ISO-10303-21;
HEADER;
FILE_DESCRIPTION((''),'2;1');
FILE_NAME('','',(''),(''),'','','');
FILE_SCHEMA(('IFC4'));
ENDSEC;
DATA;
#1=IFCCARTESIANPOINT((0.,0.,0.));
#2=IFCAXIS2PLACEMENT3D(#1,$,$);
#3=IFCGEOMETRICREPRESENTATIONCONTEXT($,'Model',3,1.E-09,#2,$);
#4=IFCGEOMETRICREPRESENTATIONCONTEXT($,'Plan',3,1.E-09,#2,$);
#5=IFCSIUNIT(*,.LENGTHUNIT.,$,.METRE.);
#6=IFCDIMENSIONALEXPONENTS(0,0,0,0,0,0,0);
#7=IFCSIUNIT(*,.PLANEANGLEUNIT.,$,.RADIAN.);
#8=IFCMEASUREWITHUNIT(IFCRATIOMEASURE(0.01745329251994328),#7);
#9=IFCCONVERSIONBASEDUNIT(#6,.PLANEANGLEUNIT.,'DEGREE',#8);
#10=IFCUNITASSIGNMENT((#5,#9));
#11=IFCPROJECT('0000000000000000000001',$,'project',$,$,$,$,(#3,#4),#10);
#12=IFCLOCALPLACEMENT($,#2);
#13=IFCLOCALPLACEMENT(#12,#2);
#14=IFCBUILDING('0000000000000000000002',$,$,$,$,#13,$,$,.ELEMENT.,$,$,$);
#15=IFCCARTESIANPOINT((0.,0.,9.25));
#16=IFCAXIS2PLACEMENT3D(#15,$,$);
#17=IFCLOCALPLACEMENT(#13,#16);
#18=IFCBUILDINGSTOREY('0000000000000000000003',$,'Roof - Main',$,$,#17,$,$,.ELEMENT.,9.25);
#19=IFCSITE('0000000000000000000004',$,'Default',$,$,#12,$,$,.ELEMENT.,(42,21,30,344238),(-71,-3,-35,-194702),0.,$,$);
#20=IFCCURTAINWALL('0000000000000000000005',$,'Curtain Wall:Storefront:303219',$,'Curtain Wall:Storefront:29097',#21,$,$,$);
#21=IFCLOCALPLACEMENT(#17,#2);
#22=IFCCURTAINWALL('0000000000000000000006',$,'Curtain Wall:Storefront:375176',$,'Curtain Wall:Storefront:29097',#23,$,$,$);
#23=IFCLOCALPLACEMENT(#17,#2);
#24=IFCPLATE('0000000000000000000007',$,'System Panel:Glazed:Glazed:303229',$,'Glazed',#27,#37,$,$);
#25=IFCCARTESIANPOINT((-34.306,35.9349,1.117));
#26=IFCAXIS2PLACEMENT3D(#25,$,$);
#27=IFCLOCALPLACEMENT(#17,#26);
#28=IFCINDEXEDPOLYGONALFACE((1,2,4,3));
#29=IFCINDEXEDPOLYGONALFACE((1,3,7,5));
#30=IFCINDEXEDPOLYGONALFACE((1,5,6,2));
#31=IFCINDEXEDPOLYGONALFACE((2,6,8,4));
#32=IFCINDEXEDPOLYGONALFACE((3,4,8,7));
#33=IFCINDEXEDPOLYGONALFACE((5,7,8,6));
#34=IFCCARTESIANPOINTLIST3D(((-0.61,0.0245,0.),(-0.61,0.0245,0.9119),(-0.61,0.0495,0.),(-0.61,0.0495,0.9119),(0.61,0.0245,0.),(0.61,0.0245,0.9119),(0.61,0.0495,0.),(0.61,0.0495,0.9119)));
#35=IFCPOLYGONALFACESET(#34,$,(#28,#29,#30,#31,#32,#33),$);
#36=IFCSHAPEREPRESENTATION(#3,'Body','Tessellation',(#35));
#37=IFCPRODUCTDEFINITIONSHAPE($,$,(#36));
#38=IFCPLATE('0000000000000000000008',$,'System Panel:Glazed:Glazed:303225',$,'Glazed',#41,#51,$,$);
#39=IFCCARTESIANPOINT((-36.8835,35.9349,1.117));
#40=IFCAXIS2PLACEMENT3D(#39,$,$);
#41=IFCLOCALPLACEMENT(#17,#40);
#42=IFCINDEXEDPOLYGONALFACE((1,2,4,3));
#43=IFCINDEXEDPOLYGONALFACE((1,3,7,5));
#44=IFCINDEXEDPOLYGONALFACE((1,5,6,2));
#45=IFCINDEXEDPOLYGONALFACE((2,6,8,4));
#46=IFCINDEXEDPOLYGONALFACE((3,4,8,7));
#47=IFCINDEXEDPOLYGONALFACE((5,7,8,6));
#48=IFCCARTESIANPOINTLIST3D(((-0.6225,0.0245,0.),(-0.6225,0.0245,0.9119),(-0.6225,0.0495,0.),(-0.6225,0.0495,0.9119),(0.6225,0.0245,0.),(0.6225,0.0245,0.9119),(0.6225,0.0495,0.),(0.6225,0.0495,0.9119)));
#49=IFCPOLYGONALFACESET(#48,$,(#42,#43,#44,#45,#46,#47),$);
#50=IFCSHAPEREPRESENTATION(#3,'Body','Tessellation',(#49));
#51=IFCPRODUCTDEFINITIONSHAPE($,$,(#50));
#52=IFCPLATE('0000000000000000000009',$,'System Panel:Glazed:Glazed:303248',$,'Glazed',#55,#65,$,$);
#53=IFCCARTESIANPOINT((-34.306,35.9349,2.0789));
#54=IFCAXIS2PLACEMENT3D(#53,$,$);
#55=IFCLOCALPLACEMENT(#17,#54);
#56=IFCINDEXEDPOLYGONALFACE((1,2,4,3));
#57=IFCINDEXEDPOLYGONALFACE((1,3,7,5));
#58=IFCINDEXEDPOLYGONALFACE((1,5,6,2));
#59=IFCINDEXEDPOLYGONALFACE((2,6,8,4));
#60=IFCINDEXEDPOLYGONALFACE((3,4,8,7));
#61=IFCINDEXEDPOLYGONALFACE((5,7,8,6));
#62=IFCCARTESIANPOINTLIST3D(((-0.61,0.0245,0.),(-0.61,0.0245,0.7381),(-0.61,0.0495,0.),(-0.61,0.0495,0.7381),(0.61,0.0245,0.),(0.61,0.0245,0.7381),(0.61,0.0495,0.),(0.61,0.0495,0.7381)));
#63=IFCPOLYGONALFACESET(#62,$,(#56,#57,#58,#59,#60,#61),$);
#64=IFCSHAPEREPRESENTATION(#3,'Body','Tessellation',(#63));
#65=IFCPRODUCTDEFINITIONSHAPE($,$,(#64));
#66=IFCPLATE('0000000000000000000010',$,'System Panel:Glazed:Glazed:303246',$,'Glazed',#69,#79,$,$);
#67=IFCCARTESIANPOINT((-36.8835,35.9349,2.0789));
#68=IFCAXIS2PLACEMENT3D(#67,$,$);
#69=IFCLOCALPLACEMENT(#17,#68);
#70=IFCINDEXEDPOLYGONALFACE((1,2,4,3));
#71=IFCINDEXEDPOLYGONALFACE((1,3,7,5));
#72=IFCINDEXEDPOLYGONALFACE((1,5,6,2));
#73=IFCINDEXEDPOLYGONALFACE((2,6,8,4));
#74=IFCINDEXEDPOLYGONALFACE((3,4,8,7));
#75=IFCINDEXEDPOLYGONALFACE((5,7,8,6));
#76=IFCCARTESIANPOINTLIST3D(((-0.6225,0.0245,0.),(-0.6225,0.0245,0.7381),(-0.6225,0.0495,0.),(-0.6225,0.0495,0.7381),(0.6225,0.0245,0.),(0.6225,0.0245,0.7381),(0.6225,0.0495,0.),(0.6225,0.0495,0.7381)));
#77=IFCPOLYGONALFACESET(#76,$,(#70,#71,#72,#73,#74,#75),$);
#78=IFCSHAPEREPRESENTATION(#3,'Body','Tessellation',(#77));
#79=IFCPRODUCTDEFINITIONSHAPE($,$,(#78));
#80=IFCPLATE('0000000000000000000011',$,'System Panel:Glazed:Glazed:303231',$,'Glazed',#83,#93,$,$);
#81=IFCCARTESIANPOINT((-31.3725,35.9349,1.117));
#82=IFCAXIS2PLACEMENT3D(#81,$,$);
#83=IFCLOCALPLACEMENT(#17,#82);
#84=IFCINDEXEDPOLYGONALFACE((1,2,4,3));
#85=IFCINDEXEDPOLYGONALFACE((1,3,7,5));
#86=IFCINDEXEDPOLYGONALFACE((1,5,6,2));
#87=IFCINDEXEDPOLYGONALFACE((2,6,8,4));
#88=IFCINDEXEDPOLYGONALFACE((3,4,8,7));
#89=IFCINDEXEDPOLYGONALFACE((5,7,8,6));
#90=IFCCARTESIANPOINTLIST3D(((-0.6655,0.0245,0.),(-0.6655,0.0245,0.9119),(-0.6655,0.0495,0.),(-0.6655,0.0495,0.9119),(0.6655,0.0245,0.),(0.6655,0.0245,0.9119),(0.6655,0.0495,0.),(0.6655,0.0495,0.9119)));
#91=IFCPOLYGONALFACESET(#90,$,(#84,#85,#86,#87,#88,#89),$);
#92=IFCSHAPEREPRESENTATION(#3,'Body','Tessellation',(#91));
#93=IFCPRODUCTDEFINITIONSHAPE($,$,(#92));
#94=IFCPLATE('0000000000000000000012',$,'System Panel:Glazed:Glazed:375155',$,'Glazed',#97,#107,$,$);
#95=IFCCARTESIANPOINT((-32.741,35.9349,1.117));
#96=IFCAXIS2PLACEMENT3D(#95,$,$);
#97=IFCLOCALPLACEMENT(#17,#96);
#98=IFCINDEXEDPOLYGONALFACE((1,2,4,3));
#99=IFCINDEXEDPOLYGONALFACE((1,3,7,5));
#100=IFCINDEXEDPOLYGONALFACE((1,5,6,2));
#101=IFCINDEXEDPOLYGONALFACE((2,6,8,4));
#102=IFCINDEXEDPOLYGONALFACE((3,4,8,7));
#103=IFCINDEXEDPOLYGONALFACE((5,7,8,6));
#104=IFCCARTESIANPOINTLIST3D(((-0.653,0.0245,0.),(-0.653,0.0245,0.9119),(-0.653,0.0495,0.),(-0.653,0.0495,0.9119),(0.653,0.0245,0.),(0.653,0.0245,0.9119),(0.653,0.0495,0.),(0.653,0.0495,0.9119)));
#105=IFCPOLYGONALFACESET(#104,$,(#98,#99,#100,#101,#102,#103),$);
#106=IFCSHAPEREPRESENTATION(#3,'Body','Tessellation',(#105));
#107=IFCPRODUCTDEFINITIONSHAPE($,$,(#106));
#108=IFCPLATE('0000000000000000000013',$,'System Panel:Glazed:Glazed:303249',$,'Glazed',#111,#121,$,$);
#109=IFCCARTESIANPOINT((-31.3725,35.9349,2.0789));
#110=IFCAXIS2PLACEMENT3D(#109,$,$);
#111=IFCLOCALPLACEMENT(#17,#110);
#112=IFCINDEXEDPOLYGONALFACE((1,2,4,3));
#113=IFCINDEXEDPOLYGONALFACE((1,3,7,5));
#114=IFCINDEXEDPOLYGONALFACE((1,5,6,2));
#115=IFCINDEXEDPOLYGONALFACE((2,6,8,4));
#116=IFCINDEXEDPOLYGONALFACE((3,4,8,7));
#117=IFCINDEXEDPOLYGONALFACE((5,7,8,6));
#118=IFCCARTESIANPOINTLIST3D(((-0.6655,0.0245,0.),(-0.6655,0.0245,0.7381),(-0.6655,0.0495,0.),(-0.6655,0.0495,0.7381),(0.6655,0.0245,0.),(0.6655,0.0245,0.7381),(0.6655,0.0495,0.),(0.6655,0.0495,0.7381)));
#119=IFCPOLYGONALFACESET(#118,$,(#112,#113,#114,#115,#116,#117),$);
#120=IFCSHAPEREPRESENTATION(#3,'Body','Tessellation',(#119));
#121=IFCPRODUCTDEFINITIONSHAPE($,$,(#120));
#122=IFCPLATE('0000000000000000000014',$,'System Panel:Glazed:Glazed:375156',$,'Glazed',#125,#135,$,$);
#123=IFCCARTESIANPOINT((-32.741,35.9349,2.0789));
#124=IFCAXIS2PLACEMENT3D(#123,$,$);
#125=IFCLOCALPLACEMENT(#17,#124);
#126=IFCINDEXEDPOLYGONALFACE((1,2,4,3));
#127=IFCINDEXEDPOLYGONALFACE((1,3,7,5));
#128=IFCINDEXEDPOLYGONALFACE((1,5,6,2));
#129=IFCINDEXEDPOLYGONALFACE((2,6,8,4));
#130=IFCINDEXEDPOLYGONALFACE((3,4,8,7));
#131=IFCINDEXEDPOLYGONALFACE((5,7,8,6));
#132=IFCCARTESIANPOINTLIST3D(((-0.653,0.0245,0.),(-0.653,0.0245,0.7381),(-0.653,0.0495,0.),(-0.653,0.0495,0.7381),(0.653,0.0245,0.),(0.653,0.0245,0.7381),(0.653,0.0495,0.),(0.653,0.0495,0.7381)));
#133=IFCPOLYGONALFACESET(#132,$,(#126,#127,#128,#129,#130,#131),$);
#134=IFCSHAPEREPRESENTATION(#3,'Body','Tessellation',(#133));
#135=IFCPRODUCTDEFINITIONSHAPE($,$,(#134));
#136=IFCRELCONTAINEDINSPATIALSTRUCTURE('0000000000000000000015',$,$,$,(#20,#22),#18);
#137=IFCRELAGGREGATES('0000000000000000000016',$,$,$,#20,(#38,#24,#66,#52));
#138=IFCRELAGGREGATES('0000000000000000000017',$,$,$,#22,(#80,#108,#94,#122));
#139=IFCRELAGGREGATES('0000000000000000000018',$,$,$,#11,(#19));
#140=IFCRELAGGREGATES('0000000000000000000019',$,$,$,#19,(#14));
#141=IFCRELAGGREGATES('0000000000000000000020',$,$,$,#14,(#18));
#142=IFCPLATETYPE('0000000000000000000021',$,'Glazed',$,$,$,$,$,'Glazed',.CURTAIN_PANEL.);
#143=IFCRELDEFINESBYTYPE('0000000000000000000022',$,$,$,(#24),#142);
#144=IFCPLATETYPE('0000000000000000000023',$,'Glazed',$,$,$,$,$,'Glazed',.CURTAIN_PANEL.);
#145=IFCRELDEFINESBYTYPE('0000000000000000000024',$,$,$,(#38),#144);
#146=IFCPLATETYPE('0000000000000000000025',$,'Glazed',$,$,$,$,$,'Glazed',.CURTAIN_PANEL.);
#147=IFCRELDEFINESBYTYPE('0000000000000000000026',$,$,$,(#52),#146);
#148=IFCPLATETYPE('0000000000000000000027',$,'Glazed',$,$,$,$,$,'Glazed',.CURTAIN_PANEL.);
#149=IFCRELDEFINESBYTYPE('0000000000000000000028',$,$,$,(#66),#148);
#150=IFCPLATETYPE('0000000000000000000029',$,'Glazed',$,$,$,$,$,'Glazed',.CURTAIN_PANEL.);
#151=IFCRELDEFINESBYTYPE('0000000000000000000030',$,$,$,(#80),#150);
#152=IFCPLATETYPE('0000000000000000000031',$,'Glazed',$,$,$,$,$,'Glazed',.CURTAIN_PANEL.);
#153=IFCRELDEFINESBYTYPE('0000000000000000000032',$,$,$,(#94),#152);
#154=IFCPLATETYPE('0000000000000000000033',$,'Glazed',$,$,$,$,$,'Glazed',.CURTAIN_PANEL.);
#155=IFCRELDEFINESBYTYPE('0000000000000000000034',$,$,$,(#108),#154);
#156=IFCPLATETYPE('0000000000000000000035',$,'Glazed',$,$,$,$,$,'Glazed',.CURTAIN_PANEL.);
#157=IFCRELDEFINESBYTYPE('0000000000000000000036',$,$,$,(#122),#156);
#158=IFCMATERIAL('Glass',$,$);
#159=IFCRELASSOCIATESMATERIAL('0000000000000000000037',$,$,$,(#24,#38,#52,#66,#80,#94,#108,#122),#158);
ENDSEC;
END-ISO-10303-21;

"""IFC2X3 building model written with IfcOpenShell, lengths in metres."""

from ifc_helpers import new_model, entity, si_unit, converted_unit, frame, origin, origin_2d_with_axis, place, context, project, spatial, rectangle, extrude, source, transform, mapped, material, type_object, type_shapes, element, aggregate, save


model = new_model("IFC2X3")

# Units and contexts
model_context = context("Model", 3, precision=1e-09, world=origin())
plan_context = context("Plan", 3, precision=1e-09, world=origin())
ifc_project = project(units=[si_unit("LENGTHUNIT", "METRE"), converted_unit("PLANEANGLEUNIT", "DEGREE", entity("IfcRatioMeasure", 0.01745329251994328), si_unit("PLANEANGLEUNIT", "RADIAN"), dimensions=[0, 0, 0, 0, 0, 0, 0])], contexts=[model_context, plan_context])

# Site, building, storey
site_placement = place(None, origin())
site = spatial("IfcSite", under=ifc_project, at=site_placement, Name="Default", CompositionType="ELEMENT", RefLatitude=(42, 21, 30, 344238), RefLongitude=(-71, -3, -35, -194702), RefElevation=0.0)
building_placement = place(site_placement, origin())
building = spatial("IfcBuilding", under=site, at=building_placement, CompositionType="ELEMENT")
storey_placement = place(building_placement, frame((0.0, 0.0, 9.25)))
storey = spatial("IfcBuildingStorey", under=building, at=storey_placement, Name="Roof - Main", CompositionType="ELEMENT", Elevation=9.25)

# Curtain wall
curtain_wall_1_placement = place(storey_placement, origin())
curtain_wall_1 = element("IfcCurtainWall", 1, at=curtain_wall_1_placement, inside=storey, Name="Curtain Wall:Storefront:303219", ObjectType="Curtain Wall:Storefront:29097")

# Curtain wall
curtain_wall_2_placement = place(storey_placement, origin())
curtain_wall_2 = element("IfcCurtainWall", 2, at=curtain_wall_2_placement, inside=storey, Name="Curtain Wall:Storefront:375176", ObjectType="Curtain Wall:Storefront:29097")

# Plates
ifc_material_1 = material(Name="Glass")
plate_type_1 = type_object("IfcPlateType", Name="Glazed", ElementType="Glazed", PredefinedType="CURTAIN_PANEL")
shared_shape_1 = source(origin(), model_context, "Body", "SweptSolid", [
    extrude(rectangle(XDim=0.025, YDim=1.22, at=origin_2d_with_axis()), frame((0.0, 0.037, 0.0), z_axis=(0.0, 0.0, 1.0), x_axis=(0.0, 1.0, 0.0)), (0.0, 0.0, 1.0), 0.9119),
])
type_shapes(plate_type_1, [shared_shape_1])
plate_1_placement = place(storey_placement, frame((-34.306, 35.9349, 1.117)))
plate_1 = element("IfcPlate", 3, at=plate_1_placement, type_object=plate_type_1, material=ifc_material_1, Name="System Panel:Glazed:Glazed:303229", ObjectType="Glazed", context=model_context, shape_type="MappedRepresentation", body=[
    mapped(shared_shape_1, transform((0.0, 0.0, 0.0), scale=1.0)),
])
plate_type_2 = type_object("IfcPlateType", Name="Glazed", ElementType="Glazed", PredefinedType="CURTAIN_PANEL")
shared_shape_2 = source(origin(), model_context, "Body", "SweptSolid", [
    extrude(rectangle(XDim=0.025, YDim=1.245, at=origin_2d_with_axis()), frame((0.0, 0.037, 0.0), z_axis=(0.0, 0.0, 1.0), x_axis=(0.0, 1.0, 0.0)), (0.0, 0.0, 1.0), 0.9119),
])
type_shapes(plate_type_2, [shared_shape_2])
plate_2_placement = place(storey_placement, frame((-36.8835, 35.9349, 1.117)))
plate_2 = element("IfcPlate", 4, at=plate_2_placement, type_object=plate_type_2, material=ifc_material_1, Name="System Panel:Glazed:Glazed:303225", ObjectType="Glazed", context=model_context, shape_type="MappedRepresentation", body=[
    mapped(shared_shape_2, transform((0.0, 0.0, 0.0), scale=1.0)),
])
plate_type_3 = type_object("IfcPlateType", Name="Glazed", ElementType="Glazed", PredefinedType="CURTAIN_PANEL")
shared_shape_3 = source(origin(), model_context, "Body", "SweptSolid", [
    extrude(rectangle(XDim=0.025, YDim=1.22, at=origin_2d_with_axis()), frame((0.0, 0.037, 0.0), z_axis=(0.0, 0.0, 1.0), x_axis=(0.0, 1.0, 0.0)), (0.0, 0.0, 1.0), 0.7381),
])
type_shapes(plate_type_3, [shared_shape_3])
plate_3_placement = place(storey_placement, frame((-34.306, 35.9349, 2.0789)))
plate_3 = element("IfcPlate", 5, at=plate_3_placement, type_object=plate_type_3, material=ifc_material_1, Name="System Panel:Glazed:Glazed:303248", ObjectType="Glazed", context=model_context, shape_type="MappedRepresentation", body=[
    mapped(shared_shape_3, transform((0.0, 0.0, 0.0), scale=1.0)),
])
plate_type_4 = type_object("IfcPlateType", Name="Glazed", ElementType="Glazed", PredefinedType="CURTAIN_PANEL")
shared_shape_4 = source(origin(), model_context, "Body", "SweptSolid", [
    extrude(rectangle(XDim=0.025, YDim=1.245, at=origin_2d_with_axis()), frame((0.0, 0.037, 0.0), z_axis=(0.0, 0.0, 1.0), x_axis=(0.0, 1.0, 0.0)), (0.0, 0.0, 1.0), 0.7381),
])
type_shapes(plate_type_4, [shared_shape_4])
plate_4_placement = place(storey_placement, frame((-36.8835, 35.9349, 2.0789)))
plate_4 = element("IfcPlate", 6, at=plate_4_placement, type_object=plate_type_4, material=ifc_material_1, Name="System Panel:Glazed:Glazed:303246", ObjectType="Glazed", context=model_context, shape_type="MappedRepresentation", body=[
    mapped(shared_shape_4, transform((0.0, 0.0, 0.0), scale=1.0)),
])
aggregate(curtain_wall_1, [plate_2, plate_1, plate_4, plate_3])
plate_type_5 = type_object("IfcPlateType", Name="Glazed", ElementType="Glazed", PredefinedType="CURTAIN_PANEL")
shared_shape_5 = source(origin(), model_context, "Body", "SweptSolid", [
    extrude(rectangle(XDim=0.025, YDim=1.331, at=origin_2d_with_axis()), frame((0.0, 0.037, 0.0), z_axis=(0.0, 0.0, 1.0), x_axis=(0.0, 1.0, 0.0)), (0.0, 0.0, 1.0), 0.9119),
])
type_shapes(plate_type_5, [shared_shape_5])
plate_5_placement = place(storey_placement, frame((-31.3725, 35.9349, 1.117)))
plate_5 = element("IfcPlate", 7, at=plate_5_placement, type_object=plate_type_5, material=ifc_material_1, Name="System Panel:Glazed:Glazed:303231", ObjectType="Glazed", context=model_context, shape_type="MappedRepresentation", body=[
    mapped(shared_shape_5, transform((0.0, 0.0, 0.0), scale=1.0)),
])
plate_type_6 = type_object("IfcPlateType", Name="Glazed", ElementType="Glazed", PredefinedType="CURTAIN_PANEL")
shared_shape_6 = source(origin(), model_context, "Body", "SweptSolid", [
    extrude(rectangle(XDim=0.025, YDim=1.306, at=origin_2d_with_axis()), frame((0.0, 0.037, 0.0), z_axis=(0.0, 0.0, 1.0), x_axis=(0.0, 1.0, 0.0)), (0.0, 0.0, 1.0), 0.9119),
])
type_shapes(plate_type_6, [shared_shape_6])
plate_6_placement = place(storey_placement, frame((-32.741, 35.9349, 1.117)))
plate_6 = element("IfcPlate", 8, at=plate_6_placement, type_object=plate_type_6, material=ifc_material_1, Name="System Panel:Glazed:Glazed:375155", ObjectType="Glazed", context=model_context, shape_type="MappedRepresentation", body=[
    mapped(shared_shape_6, transform((0.0, 0.0, 0.0), scale=1.0)),
])
plate_type_7 = type_object("IfcPlateType", Name="Glazed", ElementType="Glazed", PredefinedType="CURTAIN_PANEL")
shared_shape_7 = source(origin(), model_context, "Body", "SweptSolid", [
    extrude(rectangle(XDim=0.025, YDim=1.331, at=origin_2d_with_axis()), frame((0.0, 0.037, 0.0), z_axis=(0.0, 0.0, 1.0), x_axis=(0.0, 1.0, 0.0)), (0.0, 0.0, 1.0), 0.7381),
])
type_shapes(plate_type_7, [shared_shape_7])
plate_7_placement = place(storey_placement, frame((-31.3725, 35.9349, 2.0789)))
plate_7 = element("IfcPlate", 9, at=plate_7_placement, type_object=plate_type_7, material=ifc_material_1, Name="System Panel:Glazed:Glazed:303249", ObjectType="Glazed", context=model_context, shape_type="MappedRepresentation", body=[
    mapped(shared_shape_7, transform((0.0, 0.0, 0.0), scale=1.0)),
])
plate_type_8 = type_object("IfcPlateType", Name="Glazed", ElementType="Glazed", PredefinedType="CURTAIN_PANEL")
shared_shape_8 = source(origin(), model_context, "Body", "SweptSolid", [
    extrude(rectangle(XDim=0.025, YDim=1.306, at=origin_2d_with_axis()), frame((0.0, 0.037, 0.0), z_axis=(0.0, 0.0, 1.0), x_axis=(0.0, 1.0, 0.0)), (0.0, 0.0, 1.0), 0.7381),
])
type_shapes(plate_type_8, [shared_shape_8])
plate_8_placement = place(storey_placement, frame((-32.741, 35.9349, 2.0789)))
plate_8 = element("IfcPlate", 10, at=plate_8_placement, type_object=plate_type_8, material=ifc_material_1, Name="System Panel:Glazed:Glazed:375156", ObjectType="Glazed", context=model_context, shape_type="MappedRepresentation", body=[
    mapped(shared_shape_8, transform((0.0, 0.0, 0.0), scale=1.0)),
])
aggregate(curtain_wall_2, [plate_5, plate_7, plate_6, plate_8])

save(model, "model.ifc")
